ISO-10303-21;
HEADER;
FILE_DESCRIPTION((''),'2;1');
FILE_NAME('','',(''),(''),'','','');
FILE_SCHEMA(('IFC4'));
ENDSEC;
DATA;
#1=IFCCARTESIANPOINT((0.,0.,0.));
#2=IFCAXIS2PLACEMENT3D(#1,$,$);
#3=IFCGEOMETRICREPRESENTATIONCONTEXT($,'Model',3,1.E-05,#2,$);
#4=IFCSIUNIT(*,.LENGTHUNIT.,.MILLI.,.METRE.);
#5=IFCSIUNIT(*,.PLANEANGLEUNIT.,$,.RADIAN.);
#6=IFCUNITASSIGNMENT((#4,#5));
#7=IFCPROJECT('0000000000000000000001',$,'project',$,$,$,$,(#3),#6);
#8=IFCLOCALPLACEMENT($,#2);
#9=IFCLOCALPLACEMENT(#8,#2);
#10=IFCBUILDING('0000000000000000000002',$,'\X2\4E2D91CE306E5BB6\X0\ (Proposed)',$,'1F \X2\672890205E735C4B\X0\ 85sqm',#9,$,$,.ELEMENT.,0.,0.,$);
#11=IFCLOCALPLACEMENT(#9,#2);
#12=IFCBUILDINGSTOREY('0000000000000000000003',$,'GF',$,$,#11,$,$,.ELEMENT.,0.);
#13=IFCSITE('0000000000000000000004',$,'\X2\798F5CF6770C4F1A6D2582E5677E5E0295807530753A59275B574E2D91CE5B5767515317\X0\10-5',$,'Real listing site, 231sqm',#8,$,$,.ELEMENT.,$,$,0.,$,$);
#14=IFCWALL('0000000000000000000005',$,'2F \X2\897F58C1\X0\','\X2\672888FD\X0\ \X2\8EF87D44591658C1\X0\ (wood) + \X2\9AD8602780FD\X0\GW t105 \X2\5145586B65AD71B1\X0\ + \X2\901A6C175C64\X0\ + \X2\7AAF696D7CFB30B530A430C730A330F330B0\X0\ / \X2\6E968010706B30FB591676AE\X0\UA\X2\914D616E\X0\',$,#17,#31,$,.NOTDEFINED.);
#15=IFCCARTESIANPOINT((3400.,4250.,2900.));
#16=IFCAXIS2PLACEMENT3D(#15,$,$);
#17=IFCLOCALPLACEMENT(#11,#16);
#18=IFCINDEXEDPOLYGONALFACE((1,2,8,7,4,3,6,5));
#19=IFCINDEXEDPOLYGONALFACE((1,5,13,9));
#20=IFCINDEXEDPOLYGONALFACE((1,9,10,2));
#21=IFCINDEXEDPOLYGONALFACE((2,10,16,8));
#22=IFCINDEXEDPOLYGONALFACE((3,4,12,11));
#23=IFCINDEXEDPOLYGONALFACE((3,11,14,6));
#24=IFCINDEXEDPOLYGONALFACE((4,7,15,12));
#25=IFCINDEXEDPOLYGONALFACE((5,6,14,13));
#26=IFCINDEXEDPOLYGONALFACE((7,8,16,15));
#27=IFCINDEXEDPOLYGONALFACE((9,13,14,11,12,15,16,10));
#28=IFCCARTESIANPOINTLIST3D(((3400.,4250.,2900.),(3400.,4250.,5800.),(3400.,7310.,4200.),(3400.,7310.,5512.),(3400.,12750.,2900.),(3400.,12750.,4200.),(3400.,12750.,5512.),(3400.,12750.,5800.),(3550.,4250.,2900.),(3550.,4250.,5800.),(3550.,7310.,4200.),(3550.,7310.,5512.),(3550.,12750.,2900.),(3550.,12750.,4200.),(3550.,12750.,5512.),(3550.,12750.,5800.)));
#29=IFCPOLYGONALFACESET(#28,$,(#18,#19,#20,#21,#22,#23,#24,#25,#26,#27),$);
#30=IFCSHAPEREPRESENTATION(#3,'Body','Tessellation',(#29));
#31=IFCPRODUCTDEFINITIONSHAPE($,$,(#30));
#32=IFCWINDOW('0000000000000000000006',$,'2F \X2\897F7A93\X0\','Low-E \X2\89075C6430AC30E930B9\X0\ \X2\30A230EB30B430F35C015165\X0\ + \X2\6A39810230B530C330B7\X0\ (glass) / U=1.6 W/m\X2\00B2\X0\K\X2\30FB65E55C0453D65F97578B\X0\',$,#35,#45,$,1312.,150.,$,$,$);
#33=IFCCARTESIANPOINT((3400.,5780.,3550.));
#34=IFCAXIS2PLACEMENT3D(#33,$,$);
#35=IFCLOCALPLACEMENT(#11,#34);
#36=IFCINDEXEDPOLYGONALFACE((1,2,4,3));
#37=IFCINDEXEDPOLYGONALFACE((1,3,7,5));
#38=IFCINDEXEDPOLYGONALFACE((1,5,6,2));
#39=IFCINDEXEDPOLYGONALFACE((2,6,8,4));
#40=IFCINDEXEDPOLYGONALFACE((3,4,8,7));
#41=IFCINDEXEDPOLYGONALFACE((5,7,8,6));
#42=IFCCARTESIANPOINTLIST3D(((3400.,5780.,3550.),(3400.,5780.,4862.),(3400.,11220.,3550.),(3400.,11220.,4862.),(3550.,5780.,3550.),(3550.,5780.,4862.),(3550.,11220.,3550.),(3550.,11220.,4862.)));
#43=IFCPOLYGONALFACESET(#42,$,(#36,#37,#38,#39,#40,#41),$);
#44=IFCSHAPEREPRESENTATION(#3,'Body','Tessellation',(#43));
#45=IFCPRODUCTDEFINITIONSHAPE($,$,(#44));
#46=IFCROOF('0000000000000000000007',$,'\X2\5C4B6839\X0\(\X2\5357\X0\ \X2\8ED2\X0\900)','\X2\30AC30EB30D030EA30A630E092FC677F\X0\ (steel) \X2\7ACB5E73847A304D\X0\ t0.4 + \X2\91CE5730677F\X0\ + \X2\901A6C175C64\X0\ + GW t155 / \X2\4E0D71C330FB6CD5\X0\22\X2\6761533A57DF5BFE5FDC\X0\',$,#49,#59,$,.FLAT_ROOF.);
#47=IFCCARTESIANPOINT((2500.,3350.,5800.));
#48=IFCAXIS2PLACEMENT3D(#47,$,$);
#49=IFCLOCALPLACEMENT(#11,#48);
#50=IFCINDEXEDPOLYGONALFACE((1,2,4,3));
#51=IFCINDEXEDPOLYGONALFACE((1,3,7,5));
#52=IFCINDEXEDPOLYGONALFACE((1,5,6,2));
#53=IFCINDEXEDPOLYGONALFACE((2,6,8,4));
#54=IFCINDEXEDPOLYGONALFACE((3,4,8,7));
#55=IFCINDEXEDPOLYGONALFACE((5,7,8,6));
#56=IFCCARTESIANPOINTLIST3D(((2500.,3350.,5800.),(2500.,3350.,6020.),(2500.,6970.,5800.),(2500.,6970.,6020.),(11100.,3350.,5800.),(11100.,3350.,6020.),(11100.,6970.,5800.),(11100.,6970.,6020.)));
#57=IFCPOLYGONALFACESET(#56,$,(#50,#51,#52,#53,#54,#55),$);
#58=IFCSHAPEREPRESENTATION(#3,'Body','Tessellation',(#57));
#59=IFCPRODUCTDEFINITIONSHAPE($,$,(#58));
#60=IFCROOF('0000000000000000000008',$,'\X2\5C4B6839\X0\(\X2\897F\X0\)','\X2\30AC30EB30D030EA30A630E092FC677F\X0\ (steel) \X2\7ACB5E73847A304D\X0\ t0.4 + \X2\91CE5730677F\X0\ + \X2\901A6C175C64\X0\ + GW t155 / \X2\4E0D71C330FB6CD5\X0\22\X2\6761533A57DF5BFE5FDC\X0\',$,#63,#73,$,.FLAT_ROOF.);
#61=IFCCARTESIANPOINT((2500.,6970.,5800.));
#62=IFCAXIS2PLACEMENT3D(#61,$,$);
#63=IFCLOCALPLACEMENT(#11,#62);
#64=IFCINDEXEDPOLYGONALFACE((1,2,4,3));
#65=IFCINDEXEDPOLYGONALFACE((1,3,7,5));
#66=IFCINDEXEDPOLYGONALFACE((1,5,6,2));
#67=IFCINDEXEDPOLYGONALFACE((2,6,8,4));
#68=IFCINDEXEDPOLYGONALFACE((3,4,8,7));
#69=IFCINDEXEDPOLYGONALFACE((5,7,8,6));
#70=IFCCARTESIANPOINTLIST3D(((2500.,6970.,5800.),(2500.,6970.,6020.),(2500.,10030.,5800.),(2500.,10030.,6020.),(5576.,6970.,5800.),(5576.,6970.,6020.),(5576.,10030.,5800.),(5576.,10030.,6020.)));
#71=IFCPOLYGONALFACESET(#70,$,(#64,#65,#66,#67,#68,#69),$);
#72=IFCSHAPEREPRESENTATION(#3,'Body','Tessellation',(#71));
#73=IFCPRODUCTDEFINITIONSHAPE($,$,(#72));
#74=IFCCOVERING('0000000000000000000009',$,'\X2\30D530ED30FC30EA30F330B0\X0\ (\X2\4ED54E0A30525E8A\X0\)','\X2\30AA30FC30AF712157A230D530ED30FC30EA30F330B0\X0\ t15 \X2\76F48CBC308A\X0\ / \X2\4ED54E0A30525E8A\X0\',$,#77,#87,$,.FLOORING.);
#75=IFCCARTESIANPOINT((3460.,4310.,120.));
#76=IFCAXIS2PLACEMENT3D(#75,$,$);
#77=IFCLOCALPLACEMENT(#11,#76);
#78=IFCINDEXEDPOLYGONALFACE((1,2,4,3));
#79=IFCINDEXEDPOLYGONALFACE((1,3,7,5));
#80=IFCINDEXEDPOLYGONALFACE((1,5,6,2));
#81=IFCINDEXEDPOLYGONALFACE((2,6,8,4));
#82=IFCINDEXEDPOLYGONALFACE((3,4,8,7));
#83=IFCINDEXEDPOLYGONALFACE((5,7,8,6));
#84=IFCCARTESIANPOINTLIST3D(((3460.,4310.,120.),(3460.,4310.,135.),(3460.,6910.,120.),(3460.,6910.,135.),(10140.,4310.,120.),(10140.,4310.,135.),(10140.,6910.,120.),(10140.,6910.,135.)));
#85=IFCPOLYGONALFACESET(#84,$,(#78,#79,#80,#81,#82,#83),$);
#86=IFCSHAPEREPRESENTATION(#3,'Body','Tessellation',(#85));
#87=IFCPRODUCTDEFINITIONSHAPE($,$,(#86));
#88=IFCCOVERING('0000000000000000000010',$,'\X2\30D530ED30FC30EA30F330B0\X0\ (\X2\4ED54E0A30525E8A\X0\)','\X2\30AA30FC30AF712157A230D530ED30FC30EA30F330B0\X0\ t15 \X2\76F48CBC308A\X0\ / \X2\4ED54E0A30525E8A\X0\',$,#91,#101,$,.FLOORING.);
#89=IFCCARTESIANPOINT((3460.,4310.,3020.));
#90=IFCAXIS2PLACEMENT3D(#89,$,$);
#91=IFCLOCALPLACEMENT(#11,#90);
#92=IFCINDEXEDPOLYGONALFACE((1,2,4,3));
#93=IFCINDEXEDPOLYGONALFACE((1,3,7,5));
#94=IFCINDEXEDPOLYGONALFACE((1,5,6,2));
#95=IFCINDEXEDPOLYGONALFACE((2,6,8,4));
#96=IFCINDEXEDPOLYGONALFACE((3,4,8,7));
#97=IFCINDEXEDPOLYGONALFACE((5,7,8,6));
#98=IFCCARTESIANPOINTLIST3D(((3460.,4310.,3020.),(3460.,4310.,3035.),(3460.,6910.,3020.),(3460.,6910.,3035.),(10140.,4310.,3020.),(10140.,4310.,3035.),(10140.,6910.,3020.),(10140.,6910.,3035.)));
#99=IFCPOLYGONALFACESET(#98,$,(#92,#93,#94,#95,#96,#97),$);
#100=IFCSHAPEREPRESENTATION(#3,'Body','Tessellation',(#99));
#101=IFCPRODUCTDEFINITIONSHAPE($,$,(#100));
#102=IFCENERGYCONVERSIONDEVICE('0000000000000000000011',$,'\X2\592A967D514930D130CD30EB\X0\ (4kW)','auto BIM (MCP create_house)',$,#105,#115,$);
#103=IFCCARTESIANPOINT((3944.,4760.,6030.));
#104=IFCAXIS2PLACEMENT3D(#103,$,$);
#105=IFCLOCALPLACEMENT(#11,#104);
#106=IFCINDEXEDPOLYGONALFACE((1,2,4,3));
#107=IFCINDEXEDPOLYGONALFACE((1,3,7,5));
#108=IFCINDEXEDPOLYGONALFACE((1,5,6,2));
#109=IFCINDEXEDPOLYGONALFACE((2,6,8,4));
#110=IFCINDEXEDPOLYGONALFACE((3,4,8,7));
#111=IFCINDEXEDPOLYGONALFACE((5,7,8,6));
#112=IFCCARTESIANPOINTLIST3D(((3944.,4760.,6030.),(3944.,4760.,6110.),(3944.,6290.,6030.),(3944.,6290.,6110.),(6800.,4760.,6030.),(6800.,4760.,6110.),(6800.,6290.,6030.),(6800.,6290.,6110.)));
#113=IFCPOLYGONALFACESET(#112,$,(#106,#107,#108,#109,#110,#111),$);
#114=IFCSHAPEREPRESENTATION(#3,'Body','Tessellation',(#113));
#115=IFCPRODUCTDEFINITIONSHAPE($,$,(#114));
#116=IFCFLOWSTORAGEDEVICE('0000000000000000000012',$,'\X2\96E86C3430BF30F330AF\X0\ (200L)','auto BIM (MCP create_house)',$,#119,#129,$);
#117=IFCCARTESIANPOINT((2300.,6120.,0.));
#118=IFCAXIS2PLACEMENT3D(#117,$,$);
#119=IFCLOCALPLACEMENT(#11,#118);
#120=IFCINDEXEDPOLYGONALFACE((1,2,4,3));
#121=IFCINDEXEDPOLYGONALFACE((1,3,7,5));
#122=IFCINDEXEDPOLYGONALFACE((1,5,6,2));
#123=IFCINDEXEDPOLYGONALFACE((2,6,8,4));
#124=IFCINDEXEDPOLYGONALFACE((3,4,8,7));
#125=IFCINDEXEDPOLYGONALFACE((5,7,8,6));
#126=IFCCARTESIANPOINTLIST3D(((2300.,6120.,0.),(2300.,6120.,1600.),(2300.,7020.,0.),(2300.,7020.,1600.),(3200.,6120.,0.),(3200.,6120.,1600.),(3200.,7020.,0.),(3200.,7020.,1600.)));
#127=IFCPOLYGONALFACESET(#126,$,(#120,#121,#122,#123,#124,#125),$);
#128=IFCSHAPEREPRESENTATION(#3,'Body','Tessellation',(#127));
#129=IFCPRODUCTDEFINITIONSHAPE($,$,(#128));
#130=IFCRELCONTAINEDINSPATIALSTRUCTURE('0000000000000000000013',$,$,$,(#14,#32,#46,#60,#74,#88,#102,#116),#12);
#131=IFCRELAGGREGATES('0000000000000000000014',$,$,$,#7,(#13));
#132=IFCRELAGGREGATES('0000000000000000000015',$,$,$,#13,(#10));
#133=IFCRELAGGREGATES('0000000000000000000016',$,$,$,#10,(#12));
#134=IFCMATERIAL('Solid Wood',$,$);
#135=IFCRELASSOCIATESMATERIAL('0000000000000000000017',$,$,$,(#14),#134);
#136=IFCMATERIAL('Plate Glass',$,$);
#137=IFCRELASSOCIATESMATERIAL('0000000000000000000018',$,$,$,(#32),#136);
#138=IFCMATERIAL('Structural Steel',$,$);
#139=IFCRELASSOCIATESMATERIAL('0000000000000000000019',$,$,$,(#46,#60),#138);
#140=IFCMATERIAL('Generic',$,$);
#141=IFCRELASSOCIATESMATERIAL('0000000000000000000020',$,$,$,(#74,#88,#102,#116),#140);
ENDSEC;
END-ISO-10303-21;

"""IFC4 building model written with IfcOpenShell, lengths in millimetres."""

from ifc_helpers import new_model, si_unit, frame, frame_2d, origin, place, context, project, spatial, rectangle, extrude, material, element, fill, save


model = new_model("IFC4")

# Units and contexts
model_context = context("Model", 3, precision=1e-05, world=origin())
ifc_project = project(units=[si_unit("LENGTHUNIT", "METRE", prefix="MILLI"), si_unit("PLANEANGLEUNIT", "RADIAN")], contexts=[model_context])

# Site, building, storey
site_placement = place(None, origin())
site = spatial("IfcSite", under=ifc_project, at=site_placement, Name="福島県会津若松市門田町大字中野字村北10-5", ObjectType="Real listing site, 231sqm", CompositionType="ELEMENT", RefElevation=0.0)
building_placement = place(site_placement, origin())
building = spatial("IfcBuilding", under=site, at=building_placement, Name="中野の家 (Proposed)", ObjectType="1F 木造平屋 85sqm", CompositionType="ELEMENT", ElevationOfRefHeight=0.0, ElevationOfTerrain=0.0)
storey_placement = place(building_placement, origin())
storey = spatial("IfcBuildingStorey", under=building, at=storey_placement, Name="GF", CompositionType="ELEMENT", Elevation=0.0)

# Shared definitions
ifc_material_1 = material(Name="Solid Wood")
ifc_material_2 = material(Name="Generic")

# Shared definitions
ifc_material_3 = material(Name="Plate Glass")

# Wall, opening, window
wall_1_placement = place(storey_placement, frame((3400.0, 4250.0, 2900.0)))
wall_1 = element("IfcWall", 1, at=wall_1_placement, inside=storey, material=ifc_material_1, Name="2F 西壁", Description="木製 軸組外壁 (wood) + 高性能GW t105 充填断熱 + 通気層 + 窯業系サイディング / 準耐火・外皮UA配慮", PredefinedType="NOTDEFINED", context=model_context, shape_type="SweptSolid", body=[
    extrude(rectangle(XDim=150.0, YDim=8500.0, at=frame_2d((75.0, 4250.0))), frame((3400.0, 4250.0, 2900.0)), (0.0, 0.0, 1.0), 2900.0),
])
opening_1_placement = place(storey_placement, frame((3400.0, 5780.0, 3550.0)))
opening_1 = element("IfcOpeningElement", 2, at=opening_1_placement, cuts=wall_1, PredefinedType="NOTDEFINED", context=model_context, shape_type="SweptSolid", body=[
    extrude(rectangle(XDim=150.0, YDim=5440.0, at=frame_2d((75.0, 2720.0))), frame((3400.0, 5780.0, 3550.0)), (0.0, 0.0, 1.0), 1312.0),
])
window_1_placement = place(storey_placement, frame((3400.0, 5780.0, 3550.0)))
window_1 = element("IfcWindow", 3, at=window_1_placement, inside=storey, material=ifc_material_3, Name="2F 西窓", Description="Low-E 複層ガラス アルゴン封入 + 樹脂サッシ (glass) / U=1.6 W/m²K・日射取得型", OverallHeight=1312.0, OverallWidth=150.0, context=model_context, shape_type="SweptSolid", body=[
    extrude(rectangle(XDim=150.0, YDim=5440.0, at=frame_2d((75.0, 2720.0))), frame((3400.0, 5780.0, 3550.0)), (0.0, 0.0, 1.0), 1312.0),
])
fill(opening_1, window_1)

# Roofs
ifc_material_4 = material(Name="Structural Steel")
roof_1_placement = place(storey_placement, frame((2500.0, 3350.0, 5800.0)))
element("IfcRoof", 4, at=roof_1_placement, inside=storey, material=ifc_material_4, Name="屋根(南 軒900)", Description="ガルバリウム鋼板 (steel) 立平葺き t0.4 + 野地板 + 通気層 + GW t155 / 不燃・法22条区域対応", PredefinedType="FLAT_ROOF", context=model_context, shape_type="SweptSolid", body=[
    extrude(rectangle(XDim=8600.0, YDim=3620.0, at=frame_2d((4300.0, 1810.0))), frame((2500.0, 3350.0, 5800.0)), (0.0, 0.0, 1.0), 220.0),
])
roof_2_placement = place(storey_placement, frame((2500.0, 6970.0, 5800.0)))
element("IfcRoof", 5, at=roof_2_placement, inside=storey, material=ifc_material_4, Name="屋根(西)", Description="ガルバリウム鋼板 (steel) 立平葺き t0.4 + 野地板 + 通気層 + GW t155 / 不燃・法22条区域対応", PredefinedType="FLAT_ROOF", context=model_context, shape_type="SweptSolid", body=[
    extrude(rectangle(XDim=3076.0, YDim=3060.0, at=frame_2d((1538.0, 1530.0))), frame((2500.0, 6970.0, 5800.0)), (0.0, 0.0, 1.0), 220.0),
])

# Coverings
covering_1_placement = place(storey_placement, frame((3460.0, 4310.0, 120.0)))
element("IfcCovering", 6, at=covering_1_placement, inside=storey, material=ifc_material_2, Name="フローリング (仕上げ床)", Description="オーク無垢フローリング t15 直貼り / 仕上げ床", PredefinedType="FLOORING", context=model_context, shape_type="SweptSolid", body=[
    extrude(rectangle(XDim=6680.0, YDim=2600.0, at=frame_2d((3340.0, 1300.0))), frame((3460.0, 4310.0, 120.0)), (0.0, 0.0, 1.0), 15.0),
])
covering_2_placement = place(storey_placement, frame((3460.0, 4310.0, 3020.0)))
element("IfcCovering", 7, at=covering_2_placement, inside=storey, material=ifc_material_2, Name="フローリング (仕上げ床)", Description="オーク無垢フローリング t15 直貼り / 仕上げ床", PredefinedType="FLOORING", context=model_context, shape_type="SweptSolid", body=[
    extrude(rectangle(XDim=6680.0, YDim=2600.0, at=frame_2d((3340.0, 1300.0))), frame((3460.0, 4310.0, 3020.0)), (0.0, 0.0, 1.0), 15.0),
])

# Energy conversion device
energy_conversion_device_placement = place(storey_placement, frame((3944.0, 4760.0, 6030.0)))
element("IfcEnergyConversionDevice", 8, at=energy_conversion_device_placement, inside=storey, material=ifc_material_2, Name="太陽光パネル (4kW)", Description="auto BIM (MCP create_house)", context=model_context, shape_type="SweptSolid", body=[
    extrude(rectangle(XDim=2856.0, YDim=1530.0, at=frame_2d((1428.0, 765.0))), frame((3944.0, 4760.0, 6030.0)), (0.0, 0.0, 1.0), 80.0),
])

# Flow storage device
flow_storage_device_placement = place(storey_placement, frame((2300.0, 6120.0, 0.0)))
element("IfcFlowStorageDevice", 9, at=flow_storage_device_placement, inside=storey, material=ifc_material_2, Name="雨水タンク (200L)", Description="auto BIM (MCP create_house)", context=model_context, shape_type="SweptSolid", body=[
    extrude(rectangle(XDim=900.0, YDim=900.0, at=frame_2d((450.0, 450.0))), frame((2300.0, 6120.0, 0.0)), (0.0, 0.0, 1.0), 1600.0),
])

save(model, "model.ifc")
